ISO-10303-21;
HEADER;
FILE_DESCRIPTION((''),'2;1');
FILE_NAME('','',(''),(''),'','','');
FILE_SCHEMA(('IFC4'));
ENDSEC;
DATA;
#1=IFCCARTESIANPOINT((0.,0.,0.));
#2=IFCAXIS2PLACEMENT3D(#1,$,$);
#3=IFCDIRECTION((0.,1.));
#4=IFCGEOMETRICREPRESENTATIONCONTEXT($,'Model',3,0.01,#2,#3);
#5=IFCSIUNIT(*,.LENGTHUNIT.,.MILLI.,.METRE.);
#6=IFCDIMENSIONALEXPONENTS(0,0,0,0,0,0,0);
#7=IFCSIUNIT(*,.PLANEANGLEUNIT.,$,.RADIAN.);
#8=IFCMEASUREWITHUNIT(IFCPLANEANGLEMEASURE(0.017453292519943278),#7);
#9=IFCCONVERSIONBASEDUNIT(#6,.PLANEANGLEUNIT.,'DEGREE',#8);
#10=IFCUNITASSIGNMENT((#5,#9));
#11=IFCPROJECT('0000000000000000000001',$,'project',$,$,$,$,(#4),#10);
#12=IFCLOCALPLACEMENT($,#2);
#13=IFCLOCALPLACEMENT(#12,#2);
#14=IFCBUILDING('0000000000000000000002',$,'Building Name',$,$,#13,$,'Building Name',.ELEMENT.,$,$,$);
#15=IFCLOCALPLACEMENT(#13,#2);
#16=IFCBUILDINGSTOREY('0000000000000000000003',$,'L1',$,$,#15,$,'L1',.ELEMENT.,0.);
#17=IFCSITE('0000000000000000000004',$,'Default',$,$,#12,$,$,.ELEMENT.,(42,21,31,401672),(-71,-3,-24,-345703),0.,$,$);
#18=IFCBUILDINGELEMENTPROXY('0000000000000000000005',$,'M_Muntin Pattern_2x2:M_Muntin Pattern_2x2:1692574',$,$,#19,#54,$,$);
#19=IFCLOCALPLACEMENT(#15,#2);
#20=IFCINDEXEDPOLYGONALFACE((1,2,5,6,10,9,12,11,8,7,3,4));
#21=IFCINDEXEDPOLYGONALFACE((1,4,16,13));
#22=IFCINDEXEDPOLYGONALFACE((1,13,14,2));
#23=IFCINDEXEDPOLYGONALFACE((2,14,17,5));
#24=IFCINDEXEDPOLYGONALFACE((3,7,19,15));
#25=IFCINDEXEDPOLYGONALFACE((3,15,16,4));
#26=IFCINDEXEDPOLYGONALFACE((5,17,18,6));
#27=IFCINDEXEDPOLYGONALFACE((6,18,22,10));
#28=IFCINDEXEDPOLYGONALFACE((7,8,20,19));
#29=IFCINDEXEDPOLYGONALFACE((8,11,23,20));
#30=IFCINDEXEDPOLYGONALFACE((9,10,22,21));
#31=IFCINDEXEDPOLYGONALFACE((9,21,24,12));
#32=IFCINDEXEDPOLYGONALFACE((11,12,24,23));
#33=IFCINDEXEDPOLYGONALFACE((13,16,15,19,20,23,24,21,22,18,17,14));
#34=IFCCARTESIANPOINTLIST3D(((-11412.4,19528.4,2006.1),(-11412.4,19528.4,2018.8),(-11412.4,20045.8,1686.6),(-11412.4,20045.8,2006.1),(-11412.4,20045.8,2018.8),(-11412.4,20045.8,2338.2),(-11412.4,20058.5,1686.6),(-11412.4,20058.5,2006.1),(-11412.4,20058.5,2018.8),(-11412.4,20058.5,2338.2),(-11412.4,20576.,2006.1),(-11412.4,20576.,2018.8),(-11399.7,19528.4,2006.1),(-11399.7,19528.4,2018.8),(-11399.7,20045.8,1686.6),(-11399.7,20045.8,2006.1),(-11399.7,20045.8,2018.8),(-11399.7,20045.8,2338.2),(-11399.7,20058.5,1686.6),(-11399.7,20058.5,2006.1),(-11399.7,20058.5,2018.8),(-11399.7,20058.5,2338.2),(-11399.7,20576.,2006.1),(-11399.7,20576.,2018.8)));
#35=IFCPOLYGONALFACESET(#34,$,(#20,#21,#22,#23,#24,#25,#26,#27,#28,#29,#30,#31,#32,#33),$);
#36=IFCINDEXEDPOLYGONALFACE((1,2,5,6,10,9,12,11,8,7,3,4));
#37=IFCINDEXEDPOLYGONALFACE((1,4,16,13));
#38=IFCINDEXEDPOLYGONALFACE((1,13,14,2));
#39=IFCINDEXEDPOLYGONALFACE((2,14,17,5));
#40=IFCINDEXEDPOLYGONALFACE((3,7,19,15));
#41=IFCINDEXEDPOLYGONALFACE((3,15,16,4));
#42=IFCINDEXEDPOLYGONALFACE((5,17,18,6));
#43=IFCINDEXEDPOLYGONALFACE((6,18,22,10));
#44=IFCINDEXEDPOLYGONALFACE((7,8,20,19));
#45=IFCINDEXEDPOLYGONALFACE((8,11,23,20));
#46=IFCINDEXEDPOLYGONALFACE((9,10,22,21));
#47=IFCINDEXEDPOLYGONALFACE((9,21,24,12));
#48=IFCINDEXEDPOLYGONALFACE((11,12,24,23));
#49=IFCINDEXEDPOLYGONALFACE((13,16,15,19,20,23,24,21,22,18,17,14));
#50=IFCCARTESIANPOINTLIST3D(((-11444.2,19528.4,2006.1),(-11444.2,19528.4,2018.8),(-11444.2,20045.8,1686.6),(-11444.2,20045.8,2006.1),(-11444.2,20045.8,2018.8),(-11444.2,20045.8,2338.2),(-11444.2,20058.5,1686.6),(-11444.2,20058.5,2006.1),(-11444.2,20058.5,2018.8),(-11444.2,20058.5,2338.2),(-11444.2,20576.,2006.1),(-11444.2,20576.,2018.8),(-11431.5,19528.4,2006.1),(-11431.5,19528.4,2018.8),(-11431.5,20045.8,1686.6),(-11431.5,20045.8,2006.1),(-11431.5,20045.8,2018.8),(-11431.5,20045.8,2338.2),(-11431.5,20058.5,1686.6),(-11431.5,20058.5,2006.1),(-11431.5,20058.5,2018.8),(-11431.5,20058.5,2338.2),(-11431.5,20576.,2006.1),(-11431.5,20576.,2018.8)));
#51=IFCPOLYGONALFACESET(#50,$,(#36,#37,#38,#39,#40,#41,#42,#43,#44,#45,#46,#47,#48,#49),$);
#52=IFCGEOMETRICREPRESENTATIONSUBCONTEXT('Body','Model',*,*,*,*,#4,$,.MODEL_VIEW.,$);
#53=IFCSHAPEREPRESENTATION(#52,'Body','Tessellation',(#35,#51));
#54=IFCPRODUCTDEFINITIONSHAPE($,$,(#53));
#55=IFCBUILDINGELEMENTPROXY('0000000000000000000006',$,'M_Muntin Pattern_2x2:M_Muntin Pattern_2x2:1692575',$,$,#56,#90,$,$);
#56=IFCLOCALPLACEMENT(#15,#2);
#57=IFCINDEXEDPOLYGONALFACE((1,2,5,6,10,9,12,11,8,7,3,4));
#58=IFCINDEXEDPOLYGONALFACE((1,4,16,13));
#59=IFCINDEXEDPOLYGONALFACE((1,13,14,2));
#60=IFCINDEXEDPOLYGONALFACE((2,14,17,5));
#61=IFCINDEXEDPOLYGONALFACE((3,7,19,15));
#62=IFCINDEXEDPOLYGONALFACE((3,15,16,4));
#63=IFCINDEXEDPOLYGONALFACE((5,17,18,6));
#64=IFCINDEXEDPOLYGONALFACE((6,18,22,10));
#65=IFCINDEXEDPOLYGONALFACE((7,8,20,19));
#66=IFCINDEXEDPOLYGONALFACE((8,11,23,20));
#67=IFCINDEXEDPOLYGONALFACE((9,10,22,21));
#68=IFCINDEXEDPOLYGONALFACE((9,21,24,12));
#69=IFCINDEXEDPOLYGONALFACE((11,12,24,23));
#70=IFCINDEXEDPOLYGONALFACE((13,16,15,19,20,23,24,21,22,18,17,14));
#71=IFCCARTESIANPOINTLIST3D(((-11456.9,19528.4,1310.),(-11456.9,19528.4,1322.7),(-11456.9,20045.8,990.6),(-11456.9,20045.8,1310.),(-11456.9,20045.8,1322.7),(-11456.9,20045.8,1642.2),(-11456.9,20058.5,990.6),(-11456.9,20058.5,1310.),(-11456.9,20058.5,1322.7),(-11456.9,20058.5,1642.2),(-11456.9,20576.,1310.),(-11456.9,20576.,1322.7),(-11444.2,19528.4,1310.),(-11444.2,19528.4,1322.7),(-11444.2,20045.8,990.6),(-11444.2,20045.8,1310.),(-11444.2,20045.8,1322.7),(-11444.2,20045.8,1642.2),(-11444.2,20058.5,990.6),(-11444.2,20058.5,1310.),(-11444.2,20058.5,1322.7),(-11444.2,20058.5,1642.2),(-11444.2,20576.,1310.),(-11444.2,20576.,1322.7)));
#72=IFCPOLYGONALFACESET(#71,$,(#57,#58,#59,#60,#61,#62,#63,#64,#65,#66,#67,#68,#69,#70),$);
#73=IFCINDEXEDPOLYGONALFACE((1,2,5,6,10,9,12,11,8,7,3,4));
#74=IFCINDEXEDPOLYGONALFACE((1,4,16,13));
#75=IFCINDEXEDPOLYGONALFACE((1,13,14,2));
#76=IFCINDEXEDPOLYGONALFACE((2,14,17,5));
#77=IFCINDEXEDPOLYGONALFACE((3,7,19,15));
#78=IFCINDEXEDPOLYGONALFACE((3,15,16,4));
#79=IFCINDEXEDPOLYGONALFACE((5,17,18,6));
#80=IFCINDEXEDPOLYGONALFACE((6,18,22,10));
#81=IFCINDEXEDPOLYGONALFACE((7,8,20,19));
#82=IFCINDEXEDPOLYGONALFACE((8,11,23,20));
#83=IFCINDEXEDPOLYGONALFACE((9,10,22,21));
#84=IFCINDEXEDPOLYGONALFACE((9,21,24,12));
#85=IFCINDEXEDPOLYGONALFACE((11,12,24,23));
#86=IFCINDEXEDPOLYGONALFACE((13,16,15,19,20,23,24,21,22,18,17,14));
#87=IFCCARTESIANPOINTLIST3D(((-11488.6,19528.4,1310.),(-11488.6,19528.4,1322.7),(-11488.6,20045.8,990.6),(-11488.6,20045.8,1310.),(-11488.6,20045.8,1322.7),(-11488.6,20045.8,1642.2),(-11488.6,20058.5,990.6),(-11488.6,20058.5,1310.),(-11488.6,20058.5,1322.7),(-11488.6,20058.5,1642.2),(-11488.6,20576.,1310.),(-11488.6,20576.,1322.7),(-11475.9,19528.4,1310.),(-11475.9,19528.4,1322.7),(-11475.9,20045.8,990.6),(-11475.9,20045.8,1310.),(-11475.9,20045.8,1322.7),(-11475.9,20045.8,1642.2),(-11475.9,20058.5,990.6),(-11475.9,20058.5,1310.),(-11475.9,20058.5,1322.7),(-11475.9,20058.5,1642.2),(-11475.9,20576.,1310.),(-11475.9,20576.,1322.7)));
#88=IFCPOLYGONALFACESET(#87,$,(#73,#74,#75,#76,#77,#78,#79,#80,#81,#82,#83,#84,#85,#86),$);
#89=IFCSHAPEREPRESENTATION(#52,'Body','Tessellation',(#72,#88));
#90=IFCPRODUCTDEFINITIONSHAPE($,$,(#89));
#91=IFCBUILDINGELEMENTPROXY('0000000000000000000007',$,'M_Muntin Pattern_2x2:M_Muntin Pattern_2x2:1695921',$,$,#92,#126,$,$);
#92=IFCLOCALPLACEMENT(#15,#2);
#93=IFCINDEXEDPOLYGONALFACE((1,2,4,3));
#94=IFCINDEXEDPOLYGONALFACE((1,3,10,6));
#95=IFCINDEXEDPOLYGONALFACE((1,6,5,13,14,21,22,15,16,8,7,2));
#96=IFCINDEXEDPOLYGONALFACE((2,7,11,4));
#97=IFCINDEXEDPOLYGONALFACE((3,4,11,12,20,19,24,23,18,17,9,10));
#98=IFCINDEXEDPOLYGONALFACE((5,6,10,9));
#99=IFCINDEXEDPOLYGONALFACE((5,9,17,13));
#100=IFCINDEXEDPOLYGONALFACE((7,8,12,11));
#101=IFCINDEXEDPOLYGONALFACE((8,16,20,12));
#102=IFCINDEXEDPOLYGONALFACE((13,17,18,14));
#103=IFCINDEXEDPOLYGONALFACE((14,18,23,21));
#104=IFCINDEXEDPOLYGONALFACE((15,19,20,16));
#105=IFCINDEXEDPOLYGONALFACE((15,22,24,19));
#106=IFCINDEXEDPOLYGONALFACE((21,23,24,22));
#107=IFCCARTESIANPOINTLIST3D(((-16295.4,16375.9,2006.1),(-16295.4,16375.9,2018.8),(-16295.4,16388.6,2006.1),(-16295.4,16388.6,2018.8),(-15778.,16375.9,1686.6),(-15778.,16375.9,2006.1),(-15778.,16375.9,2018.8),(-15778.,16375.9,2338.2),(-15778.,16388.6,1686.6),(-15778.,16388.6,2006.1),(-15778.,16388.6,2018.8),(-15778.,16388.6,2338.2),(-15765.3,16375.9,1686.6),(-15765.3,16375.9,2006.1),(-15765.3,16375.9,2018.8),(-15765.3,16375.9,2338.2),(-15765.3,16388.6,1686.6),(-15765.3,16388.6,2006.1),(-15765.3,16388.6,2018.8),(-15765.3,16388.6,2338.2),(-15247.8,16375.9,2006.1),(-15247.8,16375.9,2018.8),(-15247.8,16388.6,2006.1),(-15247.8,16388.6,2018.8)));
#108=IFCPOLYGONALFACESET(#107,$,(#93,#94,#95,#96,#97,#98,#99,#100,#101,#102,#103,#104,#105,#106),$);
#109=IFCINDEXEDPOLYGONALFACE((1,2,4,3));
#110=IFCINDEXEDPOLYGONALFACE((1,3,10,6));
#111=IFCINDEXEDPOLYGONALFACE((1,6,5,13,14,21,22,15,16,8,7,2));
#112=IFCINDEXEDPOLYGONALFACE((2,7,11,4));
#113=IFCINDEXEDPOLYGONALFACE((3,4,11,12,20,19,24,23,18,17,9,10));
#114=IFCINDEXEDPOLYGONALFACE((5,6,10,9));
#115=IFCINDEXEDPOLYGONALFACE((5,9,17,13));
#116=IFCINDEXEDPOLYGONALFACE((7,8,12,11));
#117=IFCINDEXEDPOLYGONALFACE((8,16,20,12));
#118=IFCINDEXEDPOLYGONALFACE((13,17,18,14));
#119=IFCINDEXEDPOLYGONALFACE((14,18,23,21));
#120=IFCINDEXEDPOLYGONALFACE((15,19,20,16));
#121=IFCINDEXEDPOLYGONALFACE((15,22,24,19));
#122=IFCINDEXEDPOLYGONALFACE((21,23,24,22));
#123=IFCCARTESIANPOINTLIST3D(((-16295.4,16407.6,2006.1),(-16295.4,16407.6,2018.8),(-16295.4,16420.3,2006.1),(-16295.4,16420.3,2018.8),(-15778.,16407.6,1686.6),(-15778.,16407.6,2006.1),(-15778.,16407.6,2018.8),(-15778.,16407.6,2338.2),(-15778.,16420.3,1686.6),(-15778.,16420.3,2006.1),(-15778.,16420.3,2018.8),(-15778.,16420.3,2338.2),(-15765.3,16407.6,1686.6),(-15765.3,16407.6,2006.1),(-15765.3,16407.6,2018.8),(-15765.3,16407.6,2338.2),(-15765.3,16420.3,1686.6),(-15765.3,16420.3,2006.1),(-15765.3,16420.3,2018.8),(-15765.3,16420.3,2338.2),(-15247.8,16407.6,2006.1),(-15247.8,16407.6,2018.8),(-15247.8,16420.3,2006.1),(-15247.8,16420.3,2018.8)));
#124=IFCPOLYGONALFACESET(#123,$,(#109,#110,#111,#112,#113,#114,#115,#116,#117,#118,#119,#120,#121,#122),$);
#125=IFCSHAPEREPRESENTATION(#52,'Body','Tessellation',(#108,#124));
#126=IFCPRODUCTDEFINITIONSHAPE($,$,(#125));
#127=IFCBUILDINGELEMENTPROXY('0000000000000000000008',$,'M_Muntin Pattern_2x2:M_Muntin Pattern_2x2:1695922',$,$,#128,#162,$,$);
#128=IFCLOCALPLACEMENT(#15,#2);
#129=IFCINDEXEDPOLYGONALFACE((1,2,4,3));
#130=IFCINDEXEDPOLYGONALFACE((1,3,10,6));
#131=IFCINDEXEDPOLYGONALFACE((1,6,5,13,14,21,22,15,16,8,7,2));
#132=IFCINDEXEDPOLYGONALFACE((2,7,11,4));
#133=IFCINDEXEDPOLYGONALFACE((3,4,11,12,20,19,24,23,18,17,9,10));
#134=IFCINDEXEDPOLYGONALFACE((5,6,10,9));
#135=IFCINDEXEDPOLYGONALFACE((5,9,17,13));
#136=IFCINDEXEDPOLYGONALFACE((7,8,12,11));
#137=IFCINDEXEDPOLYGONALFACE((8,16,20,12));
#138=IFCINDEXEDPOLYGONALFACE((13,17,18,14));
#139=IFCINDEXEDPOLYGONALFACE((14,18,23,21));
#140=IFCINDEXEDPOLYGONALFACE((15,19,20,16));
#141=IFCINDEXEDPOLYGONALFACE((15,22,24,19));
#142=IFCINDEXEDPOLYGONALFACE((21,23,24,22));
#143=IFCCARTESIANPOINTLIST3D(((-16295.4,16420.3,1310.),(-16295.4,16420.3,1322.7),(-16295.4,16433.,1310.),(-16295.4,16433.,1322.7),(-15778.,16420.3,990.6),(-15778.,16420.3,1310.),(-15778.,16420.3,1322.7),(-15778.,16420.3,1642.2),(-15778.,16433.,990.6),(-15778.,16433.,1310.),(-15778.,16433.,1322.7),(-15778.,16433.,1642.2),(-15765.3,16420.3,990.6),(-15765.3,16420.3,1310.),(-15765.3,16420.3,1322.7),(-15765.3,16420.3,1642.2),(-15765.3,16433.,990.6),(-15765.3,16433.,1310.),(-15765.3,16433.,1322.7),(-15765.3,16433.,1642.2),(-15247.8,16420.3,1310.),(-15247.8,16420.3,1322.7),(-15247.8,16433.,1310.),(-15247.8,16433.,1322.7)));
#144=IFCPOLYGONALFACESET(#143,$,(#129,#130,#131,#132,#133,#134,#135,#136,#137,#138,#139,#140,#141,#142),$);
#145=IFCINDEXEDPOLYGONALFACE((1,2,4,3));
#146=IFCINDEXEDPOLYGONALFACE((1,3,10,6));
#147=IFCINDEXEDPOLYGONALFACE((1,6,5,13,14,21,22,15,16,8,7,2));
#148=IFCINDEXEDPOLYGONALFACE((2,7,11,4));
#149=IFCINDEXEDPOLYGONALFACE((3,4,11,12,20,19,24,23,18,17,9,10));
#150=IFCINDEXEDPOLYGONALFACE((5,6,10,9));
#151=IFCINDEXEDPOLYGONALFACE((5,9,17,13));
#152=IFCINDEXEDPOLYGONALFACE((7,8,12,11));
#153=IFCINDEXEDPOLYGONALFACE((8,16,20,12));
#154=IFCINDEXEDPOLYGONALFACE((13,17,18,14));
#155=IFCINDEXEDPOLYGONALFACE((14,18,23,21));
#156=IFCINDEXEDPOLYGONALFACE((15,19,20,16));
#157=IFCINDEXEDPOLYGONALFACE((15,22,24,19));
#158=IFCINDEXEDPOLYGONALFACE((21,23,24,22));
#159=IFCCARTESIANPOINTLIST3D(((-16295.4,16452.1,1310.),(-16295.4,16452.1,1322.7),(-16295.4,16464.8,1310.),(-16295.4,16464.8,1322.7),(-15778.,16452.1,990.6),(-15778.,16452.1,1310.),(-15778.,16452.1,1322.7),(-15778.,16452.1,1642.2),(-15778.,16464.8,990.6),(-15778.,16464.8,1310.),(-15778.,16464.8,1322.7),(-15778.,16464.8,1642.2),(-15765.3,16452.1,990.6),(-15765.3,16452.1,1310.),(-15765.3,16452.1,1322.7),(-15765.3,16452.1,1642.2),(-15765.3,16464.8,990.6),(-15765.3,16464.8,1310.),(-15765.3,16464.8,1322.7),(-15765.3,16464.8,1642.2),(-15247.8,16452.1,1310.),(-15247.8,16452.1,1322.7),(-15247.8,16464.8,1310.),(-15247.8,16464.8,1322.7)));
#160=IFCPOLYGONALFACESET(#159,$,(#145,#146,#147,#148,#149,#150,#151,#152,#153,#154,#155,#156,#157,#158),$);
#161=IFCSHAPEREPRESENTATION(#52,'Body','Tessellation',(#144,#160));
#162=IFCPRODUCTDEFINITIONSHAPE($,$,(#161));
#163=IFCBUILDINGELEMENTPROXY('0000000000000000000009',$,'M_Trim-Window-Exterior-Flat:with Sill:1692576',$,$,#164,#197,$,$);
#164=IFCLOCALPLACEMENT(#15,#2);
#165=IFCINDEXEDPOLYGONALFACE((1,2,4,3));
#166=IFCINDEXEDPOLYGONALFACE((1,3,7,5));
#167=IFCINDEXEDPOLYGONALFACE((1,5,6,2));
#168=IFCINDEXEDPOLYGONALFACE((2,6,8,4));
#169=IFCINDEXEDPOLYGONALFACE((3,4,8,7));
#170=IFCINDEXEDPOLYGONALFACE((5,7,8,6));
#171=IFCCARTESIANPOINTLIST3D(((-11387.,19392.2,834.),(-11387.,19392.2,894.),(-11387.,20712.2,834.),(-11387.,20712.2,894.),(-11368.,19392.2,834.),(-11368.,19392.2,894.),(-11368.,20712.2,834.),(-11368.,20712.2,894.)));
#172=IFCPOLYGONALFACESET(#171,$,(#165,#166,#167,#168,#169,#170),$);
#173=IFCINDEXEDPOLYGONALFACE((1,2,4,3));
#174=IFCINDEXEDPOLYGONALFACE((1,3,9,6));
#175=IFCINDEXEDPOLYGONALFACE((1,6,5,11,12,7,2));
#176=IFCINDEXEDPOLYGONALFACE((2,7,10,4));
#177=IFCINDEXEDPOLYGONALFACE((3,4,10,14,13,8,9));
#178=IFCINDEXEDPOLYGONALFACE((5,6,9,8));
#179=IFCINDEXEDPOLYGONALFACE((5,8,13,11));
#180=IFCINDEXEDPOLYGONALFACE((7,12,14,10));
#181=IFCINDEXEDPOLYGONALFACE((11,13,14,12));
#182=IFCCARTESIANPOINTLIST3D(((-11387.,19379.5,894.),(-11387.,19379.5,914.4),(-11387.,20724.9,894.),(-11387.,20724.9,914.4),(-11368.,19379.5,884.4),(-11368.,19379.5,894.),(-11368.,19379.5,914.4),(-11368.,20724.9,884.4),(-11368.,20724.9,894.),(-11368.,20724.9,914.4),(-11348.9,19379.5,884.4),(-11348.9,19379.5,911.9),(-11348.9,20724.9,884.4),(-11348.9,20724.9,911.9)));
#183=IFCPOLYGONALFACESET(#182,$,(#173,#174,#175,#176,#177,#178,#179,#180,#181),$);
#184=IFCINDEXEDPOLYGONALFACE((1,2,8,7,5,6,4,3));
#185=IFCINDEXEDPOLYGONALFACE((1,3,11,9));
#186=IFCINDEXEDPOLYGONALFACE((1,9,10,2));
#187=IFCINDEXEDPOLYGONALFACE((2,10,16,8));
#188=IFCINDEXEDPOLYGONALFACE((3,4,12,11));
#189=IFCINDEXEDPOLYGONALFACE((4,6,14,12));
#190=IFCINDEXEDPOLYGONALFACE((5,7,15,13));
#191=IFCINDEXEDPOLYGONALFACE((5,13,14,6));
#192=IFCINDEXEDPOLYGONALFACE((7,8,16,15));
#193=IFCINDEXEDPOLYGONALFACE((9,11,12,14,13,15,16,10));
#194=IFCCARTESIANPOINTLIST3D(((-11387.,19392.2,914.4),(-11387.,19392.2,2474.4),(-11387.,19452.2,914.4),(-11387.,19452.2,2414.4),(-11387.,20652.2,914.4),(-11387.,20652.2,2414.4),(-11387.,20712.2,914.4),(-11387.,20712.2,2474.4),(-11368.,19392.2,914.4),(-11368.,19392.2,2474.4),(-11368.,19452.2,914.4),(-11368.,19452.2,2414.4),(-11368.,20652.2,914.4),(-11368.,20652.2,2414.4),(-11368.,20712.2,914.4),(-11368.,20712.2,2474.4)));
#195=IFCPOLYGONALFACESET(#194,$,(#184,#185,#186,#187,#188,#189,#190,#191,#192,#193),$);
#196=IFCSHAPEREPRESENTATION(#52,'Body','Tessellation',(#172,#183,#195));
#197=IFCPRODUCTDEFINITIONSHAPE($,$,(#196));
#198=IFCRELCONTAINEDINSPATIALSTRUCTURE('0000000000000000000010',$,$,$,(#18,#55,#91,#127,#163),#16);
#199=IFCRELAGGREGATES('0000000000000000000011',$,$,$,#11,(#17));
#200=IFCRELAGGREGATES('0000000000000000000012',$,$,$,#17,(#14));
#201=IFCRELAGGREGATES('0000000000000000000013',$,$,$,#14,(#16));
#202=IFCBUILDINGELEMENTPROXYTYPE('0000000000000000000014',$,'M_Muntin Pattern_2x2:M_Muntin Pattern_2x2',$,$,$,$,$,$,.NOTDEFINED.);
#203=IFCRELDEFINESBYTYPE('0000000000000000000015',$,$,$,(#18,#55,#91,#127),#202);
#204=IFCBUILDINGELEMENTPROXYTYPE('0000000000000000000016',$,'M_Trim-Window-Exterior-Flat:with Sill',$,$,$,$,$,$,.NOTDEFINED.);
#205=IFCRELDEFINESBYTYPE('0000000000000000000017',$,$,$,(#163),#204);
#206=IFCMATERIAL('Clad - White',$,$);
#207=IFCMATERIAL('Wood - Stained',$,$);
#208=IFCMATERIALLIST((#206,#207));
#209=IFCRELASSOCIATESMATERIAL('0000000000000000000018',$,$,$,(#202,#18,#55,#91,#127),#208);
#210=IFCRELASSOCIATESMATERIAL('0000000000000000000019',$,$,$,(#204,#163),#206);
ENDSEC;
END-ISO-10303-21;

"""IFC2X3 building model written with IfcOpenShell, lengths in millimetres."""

from ifc_helpers import new_model, entity, si_unit, converted_unit, direction, frame, frame_2d, origin, place, context, subcontext, project, spatial, polyline, rectangle, outline, extrude, source, transform, mapped, material, material_list, type_object, type_shapes, element, save


model = new_model("IFC2X3")

# Units and contexts
model_context = context("Model", 3, precision=0.01, world=origin(), true_north=direction((0.0, 1.0)))
body_context = subcontext(model_context, "Body", "Model", "MODEL_VIEW")
ifc_project = project(units=[si_unit("LENGTHUNIT", "METRE", prefix="MILLI"), converted_unit("PLANEANGLEUNIT", "DEGREE", entity("IfcPlaneAngleMeasure", 0.017453292519943278), si_unit("PLANEANGLEUNIT", "RADIAN"), dimensions=[0, 0, 0, 0, 0, 0, 0])], contexts=[model_context])

# Site, building, storey
site_placement = place(None, origin())
site = spatial("IfcSite", under=ifc_project, at=site_placement, Name="Default", CompositionType="ELEMENT", RefLatitude=(42, 21, 31, 401672), RefLongitude=(-71, -3, -24, -345703), RefElevation=0.0)
building_placement = place(site_placement, origin())
building = spatial("IfcBuilding", under=site, at=building_placement, Name="Building Name", LongName="Building Name", CompositionType="ELEMENT")
storey_placement = place(building_placement, origin())
storey = spatial("IfcBuildingStorey", under=building, at=storey_placement, Name="L1", LongName="L1", CompositionType="ELEMENT", Elevation=0.0)

# Shared definitions
ifc_material_1 = material(Name="Wood - Stained")

# Building element proxies
ifc_material_2 = material(Name="Clad - White")
ifc_material_list_1 = material_list([ifc_material_2, ifc_material_1])
building_element_proxy_type_1 = type_object("IfcBuildingElementProxyType", Name="M_Muntin Pattern_2x2:M_Muntin Pattern_2x2", PredefinedType="NOTDEFINED", material=ifc_material_list_1)
shared_shape_1 = source(origin(), body_context, "Body", "SweptSolid", [
    extrude(outline(polyline([(6.4, -6.4), (325.8, -6.4), (325.8, 6.3), (6.4, 6.3), (6.4, 523.8), (-6.3, 523.8), (-6.3, 6.3), (-325.8, 6.3), (-325.8, -6.4), (-6.3, -6.4), (-6.3, -523.8), (6.4, -523.8), (6.4, -6.4)])), frame((0.0, 9.5, 325.8), z_axis=(0.0, 1.0, 0.0), x_axis=(0.0, 0.0, 1.0)), (0.0, 0.0, 1.0), 12.7),
    extrude(outline(polyline([(6.4, -6.4), (325.8, -6.4), (325.8, 6.3), (6.4, 6.3), (6.4, 523.8), (-6.3, 523.8), (-6.3, 6.3), (-325.8, 6.3), (-325.8, -6.4), (-6.3, -6.4), (-6.3, -523.8), (6.4, -523.8), (6.4, -6.4)])), frame((0.0, -22.2, 325.8), z_axis=(0.0, 1.0, 0.0), x_axis=(0.0, 0.0, 1.0)), (0.0, 0.0, 1.0), 12.7),
])
type_shapes(building_element_proxy_type_1, [shared_shape_1])
for number, where, z_axis, x_axis, name in (
    (1, (-11422.0, 20052.2, 1686.6), (0.0, 0.0, 1.0), (0.0, -1.0, 0.0), "M_Muntin Pattern_2x2:M_Muntin Pattern_2x2:1692574"),
    (2, (-11466.4, 20052.2, 990.6), (0.0, 0.0, 1.0), (0.0, -1.0, 0.0), "M_Muntin Pattern_2x2:M_Muntin Pattern_2x2:1692575"),
    (3, (-15771.6, 16398.1, 1686.6), (0.0, 0.0, 1.0), (-1.0, 0.0, 0.0), "M_Muntin Pattern_2x2:M_Muntin Pattern_2x2:1695921"),
    (4, (-15771.6, 16442.5, 990.6), (0.0, 0.0, 1.0), (-1.0, 0.0, 0.0), "M_Muntin Pattern_2x2:M_Muntin Pattern_2x2:1695922"),
):
    element("IfcBuildingElementProxy", number, at=place(storey_placement, frame(where, z_axis=z_axis, x_axis=x_axis)), inside=storey, type_object=building_element_proxy_type_1, material=ifc_material_list_1, Name=name, context=body_context, shape_type="MappedRepresentation", body=[
        mapped(shared_shape_1, transform((0.0, 0.0, 0.0), scale=1.0)),
    ])
building_element_proxy_type_2 = type_object("IfcBuildingElementProxyType", Name="M_Trim-Window-Exterior-Flat:with Sill", PredefinedType="NOTDEFINED", material=ifc_material_2)
shared_shape_2 = source(origin(), body_context, "Body", "SweptSolid", [
    extrude(rectangle(XDim=1320.0, YDim=60.0, at=frame_2d((0.0, 0.0), x_axis=(1.0, 0.0))), frame((0.0, -1550.4, 0.0), z_axis=(0.0, 0.0, 1.0), x_axis=(-1.0, 0.0, 0.0)), (0.0, 0.0, 1.0), 19.0),
    extrude(outline(polyline([(-19.0, -15.2), (0.0, -15.2), (0.0, -5.7), (19.0, -5.7), (19.0, 14.8), (0.0, 14.8), (-19.0, 12.3), (-19.0, -15.2)])), frame((-672.7, -1514.8, 19.0), z_axis=(1.0, 0.0, 0.0), x_axis=(0.0, 0.0, -1.0)), (0.0, 0.0, 1.0), 1345.4),
    extrude(outline(polyline([(-795.0, -660.0), (765.0, -660.0), (765.0, -600.0), (-735.0, -600.0), (-735.0, 600.0), (765.0, 600.0), (765.0, 660.0), (-795.0, 660.0), (-795.0, -660.0)])), frame((0.0, -735.0, 0.0), z_axis=(0.0, 0.0, 1.0), x_axis=(0.0, -1.0, 0.0)), (0.0, 0.0, 1.0), 19.0),
])
type_shapes(building_element_proxy_type_2, [shared_shape_2])
for number, where, z_axis, x_axis, name in (
    (5, (-11387.0, 20052.2, 2414.4), (1.0, 0.0, 0.0), (0.0, 1.0, 0.0), "M_Trim-Window-Exterior-Flat:with Sill:1692576"),
):
    element("IfcBuildingElementProxy", number, at=place(storey_placement, frame(where, z_axis=z_axis, x_axis=x_axis)), inside=storey, type_object=building_element_proxy_type_2, material=ifc_material_2, Name=name, context=body_context, shape_type="MappedRepresentation", body=[
        mapped(shared_shape_2, transform((0.0, 0.0, 0.0), scale=1.0)),
    ])

save(model, "model.ifc")
